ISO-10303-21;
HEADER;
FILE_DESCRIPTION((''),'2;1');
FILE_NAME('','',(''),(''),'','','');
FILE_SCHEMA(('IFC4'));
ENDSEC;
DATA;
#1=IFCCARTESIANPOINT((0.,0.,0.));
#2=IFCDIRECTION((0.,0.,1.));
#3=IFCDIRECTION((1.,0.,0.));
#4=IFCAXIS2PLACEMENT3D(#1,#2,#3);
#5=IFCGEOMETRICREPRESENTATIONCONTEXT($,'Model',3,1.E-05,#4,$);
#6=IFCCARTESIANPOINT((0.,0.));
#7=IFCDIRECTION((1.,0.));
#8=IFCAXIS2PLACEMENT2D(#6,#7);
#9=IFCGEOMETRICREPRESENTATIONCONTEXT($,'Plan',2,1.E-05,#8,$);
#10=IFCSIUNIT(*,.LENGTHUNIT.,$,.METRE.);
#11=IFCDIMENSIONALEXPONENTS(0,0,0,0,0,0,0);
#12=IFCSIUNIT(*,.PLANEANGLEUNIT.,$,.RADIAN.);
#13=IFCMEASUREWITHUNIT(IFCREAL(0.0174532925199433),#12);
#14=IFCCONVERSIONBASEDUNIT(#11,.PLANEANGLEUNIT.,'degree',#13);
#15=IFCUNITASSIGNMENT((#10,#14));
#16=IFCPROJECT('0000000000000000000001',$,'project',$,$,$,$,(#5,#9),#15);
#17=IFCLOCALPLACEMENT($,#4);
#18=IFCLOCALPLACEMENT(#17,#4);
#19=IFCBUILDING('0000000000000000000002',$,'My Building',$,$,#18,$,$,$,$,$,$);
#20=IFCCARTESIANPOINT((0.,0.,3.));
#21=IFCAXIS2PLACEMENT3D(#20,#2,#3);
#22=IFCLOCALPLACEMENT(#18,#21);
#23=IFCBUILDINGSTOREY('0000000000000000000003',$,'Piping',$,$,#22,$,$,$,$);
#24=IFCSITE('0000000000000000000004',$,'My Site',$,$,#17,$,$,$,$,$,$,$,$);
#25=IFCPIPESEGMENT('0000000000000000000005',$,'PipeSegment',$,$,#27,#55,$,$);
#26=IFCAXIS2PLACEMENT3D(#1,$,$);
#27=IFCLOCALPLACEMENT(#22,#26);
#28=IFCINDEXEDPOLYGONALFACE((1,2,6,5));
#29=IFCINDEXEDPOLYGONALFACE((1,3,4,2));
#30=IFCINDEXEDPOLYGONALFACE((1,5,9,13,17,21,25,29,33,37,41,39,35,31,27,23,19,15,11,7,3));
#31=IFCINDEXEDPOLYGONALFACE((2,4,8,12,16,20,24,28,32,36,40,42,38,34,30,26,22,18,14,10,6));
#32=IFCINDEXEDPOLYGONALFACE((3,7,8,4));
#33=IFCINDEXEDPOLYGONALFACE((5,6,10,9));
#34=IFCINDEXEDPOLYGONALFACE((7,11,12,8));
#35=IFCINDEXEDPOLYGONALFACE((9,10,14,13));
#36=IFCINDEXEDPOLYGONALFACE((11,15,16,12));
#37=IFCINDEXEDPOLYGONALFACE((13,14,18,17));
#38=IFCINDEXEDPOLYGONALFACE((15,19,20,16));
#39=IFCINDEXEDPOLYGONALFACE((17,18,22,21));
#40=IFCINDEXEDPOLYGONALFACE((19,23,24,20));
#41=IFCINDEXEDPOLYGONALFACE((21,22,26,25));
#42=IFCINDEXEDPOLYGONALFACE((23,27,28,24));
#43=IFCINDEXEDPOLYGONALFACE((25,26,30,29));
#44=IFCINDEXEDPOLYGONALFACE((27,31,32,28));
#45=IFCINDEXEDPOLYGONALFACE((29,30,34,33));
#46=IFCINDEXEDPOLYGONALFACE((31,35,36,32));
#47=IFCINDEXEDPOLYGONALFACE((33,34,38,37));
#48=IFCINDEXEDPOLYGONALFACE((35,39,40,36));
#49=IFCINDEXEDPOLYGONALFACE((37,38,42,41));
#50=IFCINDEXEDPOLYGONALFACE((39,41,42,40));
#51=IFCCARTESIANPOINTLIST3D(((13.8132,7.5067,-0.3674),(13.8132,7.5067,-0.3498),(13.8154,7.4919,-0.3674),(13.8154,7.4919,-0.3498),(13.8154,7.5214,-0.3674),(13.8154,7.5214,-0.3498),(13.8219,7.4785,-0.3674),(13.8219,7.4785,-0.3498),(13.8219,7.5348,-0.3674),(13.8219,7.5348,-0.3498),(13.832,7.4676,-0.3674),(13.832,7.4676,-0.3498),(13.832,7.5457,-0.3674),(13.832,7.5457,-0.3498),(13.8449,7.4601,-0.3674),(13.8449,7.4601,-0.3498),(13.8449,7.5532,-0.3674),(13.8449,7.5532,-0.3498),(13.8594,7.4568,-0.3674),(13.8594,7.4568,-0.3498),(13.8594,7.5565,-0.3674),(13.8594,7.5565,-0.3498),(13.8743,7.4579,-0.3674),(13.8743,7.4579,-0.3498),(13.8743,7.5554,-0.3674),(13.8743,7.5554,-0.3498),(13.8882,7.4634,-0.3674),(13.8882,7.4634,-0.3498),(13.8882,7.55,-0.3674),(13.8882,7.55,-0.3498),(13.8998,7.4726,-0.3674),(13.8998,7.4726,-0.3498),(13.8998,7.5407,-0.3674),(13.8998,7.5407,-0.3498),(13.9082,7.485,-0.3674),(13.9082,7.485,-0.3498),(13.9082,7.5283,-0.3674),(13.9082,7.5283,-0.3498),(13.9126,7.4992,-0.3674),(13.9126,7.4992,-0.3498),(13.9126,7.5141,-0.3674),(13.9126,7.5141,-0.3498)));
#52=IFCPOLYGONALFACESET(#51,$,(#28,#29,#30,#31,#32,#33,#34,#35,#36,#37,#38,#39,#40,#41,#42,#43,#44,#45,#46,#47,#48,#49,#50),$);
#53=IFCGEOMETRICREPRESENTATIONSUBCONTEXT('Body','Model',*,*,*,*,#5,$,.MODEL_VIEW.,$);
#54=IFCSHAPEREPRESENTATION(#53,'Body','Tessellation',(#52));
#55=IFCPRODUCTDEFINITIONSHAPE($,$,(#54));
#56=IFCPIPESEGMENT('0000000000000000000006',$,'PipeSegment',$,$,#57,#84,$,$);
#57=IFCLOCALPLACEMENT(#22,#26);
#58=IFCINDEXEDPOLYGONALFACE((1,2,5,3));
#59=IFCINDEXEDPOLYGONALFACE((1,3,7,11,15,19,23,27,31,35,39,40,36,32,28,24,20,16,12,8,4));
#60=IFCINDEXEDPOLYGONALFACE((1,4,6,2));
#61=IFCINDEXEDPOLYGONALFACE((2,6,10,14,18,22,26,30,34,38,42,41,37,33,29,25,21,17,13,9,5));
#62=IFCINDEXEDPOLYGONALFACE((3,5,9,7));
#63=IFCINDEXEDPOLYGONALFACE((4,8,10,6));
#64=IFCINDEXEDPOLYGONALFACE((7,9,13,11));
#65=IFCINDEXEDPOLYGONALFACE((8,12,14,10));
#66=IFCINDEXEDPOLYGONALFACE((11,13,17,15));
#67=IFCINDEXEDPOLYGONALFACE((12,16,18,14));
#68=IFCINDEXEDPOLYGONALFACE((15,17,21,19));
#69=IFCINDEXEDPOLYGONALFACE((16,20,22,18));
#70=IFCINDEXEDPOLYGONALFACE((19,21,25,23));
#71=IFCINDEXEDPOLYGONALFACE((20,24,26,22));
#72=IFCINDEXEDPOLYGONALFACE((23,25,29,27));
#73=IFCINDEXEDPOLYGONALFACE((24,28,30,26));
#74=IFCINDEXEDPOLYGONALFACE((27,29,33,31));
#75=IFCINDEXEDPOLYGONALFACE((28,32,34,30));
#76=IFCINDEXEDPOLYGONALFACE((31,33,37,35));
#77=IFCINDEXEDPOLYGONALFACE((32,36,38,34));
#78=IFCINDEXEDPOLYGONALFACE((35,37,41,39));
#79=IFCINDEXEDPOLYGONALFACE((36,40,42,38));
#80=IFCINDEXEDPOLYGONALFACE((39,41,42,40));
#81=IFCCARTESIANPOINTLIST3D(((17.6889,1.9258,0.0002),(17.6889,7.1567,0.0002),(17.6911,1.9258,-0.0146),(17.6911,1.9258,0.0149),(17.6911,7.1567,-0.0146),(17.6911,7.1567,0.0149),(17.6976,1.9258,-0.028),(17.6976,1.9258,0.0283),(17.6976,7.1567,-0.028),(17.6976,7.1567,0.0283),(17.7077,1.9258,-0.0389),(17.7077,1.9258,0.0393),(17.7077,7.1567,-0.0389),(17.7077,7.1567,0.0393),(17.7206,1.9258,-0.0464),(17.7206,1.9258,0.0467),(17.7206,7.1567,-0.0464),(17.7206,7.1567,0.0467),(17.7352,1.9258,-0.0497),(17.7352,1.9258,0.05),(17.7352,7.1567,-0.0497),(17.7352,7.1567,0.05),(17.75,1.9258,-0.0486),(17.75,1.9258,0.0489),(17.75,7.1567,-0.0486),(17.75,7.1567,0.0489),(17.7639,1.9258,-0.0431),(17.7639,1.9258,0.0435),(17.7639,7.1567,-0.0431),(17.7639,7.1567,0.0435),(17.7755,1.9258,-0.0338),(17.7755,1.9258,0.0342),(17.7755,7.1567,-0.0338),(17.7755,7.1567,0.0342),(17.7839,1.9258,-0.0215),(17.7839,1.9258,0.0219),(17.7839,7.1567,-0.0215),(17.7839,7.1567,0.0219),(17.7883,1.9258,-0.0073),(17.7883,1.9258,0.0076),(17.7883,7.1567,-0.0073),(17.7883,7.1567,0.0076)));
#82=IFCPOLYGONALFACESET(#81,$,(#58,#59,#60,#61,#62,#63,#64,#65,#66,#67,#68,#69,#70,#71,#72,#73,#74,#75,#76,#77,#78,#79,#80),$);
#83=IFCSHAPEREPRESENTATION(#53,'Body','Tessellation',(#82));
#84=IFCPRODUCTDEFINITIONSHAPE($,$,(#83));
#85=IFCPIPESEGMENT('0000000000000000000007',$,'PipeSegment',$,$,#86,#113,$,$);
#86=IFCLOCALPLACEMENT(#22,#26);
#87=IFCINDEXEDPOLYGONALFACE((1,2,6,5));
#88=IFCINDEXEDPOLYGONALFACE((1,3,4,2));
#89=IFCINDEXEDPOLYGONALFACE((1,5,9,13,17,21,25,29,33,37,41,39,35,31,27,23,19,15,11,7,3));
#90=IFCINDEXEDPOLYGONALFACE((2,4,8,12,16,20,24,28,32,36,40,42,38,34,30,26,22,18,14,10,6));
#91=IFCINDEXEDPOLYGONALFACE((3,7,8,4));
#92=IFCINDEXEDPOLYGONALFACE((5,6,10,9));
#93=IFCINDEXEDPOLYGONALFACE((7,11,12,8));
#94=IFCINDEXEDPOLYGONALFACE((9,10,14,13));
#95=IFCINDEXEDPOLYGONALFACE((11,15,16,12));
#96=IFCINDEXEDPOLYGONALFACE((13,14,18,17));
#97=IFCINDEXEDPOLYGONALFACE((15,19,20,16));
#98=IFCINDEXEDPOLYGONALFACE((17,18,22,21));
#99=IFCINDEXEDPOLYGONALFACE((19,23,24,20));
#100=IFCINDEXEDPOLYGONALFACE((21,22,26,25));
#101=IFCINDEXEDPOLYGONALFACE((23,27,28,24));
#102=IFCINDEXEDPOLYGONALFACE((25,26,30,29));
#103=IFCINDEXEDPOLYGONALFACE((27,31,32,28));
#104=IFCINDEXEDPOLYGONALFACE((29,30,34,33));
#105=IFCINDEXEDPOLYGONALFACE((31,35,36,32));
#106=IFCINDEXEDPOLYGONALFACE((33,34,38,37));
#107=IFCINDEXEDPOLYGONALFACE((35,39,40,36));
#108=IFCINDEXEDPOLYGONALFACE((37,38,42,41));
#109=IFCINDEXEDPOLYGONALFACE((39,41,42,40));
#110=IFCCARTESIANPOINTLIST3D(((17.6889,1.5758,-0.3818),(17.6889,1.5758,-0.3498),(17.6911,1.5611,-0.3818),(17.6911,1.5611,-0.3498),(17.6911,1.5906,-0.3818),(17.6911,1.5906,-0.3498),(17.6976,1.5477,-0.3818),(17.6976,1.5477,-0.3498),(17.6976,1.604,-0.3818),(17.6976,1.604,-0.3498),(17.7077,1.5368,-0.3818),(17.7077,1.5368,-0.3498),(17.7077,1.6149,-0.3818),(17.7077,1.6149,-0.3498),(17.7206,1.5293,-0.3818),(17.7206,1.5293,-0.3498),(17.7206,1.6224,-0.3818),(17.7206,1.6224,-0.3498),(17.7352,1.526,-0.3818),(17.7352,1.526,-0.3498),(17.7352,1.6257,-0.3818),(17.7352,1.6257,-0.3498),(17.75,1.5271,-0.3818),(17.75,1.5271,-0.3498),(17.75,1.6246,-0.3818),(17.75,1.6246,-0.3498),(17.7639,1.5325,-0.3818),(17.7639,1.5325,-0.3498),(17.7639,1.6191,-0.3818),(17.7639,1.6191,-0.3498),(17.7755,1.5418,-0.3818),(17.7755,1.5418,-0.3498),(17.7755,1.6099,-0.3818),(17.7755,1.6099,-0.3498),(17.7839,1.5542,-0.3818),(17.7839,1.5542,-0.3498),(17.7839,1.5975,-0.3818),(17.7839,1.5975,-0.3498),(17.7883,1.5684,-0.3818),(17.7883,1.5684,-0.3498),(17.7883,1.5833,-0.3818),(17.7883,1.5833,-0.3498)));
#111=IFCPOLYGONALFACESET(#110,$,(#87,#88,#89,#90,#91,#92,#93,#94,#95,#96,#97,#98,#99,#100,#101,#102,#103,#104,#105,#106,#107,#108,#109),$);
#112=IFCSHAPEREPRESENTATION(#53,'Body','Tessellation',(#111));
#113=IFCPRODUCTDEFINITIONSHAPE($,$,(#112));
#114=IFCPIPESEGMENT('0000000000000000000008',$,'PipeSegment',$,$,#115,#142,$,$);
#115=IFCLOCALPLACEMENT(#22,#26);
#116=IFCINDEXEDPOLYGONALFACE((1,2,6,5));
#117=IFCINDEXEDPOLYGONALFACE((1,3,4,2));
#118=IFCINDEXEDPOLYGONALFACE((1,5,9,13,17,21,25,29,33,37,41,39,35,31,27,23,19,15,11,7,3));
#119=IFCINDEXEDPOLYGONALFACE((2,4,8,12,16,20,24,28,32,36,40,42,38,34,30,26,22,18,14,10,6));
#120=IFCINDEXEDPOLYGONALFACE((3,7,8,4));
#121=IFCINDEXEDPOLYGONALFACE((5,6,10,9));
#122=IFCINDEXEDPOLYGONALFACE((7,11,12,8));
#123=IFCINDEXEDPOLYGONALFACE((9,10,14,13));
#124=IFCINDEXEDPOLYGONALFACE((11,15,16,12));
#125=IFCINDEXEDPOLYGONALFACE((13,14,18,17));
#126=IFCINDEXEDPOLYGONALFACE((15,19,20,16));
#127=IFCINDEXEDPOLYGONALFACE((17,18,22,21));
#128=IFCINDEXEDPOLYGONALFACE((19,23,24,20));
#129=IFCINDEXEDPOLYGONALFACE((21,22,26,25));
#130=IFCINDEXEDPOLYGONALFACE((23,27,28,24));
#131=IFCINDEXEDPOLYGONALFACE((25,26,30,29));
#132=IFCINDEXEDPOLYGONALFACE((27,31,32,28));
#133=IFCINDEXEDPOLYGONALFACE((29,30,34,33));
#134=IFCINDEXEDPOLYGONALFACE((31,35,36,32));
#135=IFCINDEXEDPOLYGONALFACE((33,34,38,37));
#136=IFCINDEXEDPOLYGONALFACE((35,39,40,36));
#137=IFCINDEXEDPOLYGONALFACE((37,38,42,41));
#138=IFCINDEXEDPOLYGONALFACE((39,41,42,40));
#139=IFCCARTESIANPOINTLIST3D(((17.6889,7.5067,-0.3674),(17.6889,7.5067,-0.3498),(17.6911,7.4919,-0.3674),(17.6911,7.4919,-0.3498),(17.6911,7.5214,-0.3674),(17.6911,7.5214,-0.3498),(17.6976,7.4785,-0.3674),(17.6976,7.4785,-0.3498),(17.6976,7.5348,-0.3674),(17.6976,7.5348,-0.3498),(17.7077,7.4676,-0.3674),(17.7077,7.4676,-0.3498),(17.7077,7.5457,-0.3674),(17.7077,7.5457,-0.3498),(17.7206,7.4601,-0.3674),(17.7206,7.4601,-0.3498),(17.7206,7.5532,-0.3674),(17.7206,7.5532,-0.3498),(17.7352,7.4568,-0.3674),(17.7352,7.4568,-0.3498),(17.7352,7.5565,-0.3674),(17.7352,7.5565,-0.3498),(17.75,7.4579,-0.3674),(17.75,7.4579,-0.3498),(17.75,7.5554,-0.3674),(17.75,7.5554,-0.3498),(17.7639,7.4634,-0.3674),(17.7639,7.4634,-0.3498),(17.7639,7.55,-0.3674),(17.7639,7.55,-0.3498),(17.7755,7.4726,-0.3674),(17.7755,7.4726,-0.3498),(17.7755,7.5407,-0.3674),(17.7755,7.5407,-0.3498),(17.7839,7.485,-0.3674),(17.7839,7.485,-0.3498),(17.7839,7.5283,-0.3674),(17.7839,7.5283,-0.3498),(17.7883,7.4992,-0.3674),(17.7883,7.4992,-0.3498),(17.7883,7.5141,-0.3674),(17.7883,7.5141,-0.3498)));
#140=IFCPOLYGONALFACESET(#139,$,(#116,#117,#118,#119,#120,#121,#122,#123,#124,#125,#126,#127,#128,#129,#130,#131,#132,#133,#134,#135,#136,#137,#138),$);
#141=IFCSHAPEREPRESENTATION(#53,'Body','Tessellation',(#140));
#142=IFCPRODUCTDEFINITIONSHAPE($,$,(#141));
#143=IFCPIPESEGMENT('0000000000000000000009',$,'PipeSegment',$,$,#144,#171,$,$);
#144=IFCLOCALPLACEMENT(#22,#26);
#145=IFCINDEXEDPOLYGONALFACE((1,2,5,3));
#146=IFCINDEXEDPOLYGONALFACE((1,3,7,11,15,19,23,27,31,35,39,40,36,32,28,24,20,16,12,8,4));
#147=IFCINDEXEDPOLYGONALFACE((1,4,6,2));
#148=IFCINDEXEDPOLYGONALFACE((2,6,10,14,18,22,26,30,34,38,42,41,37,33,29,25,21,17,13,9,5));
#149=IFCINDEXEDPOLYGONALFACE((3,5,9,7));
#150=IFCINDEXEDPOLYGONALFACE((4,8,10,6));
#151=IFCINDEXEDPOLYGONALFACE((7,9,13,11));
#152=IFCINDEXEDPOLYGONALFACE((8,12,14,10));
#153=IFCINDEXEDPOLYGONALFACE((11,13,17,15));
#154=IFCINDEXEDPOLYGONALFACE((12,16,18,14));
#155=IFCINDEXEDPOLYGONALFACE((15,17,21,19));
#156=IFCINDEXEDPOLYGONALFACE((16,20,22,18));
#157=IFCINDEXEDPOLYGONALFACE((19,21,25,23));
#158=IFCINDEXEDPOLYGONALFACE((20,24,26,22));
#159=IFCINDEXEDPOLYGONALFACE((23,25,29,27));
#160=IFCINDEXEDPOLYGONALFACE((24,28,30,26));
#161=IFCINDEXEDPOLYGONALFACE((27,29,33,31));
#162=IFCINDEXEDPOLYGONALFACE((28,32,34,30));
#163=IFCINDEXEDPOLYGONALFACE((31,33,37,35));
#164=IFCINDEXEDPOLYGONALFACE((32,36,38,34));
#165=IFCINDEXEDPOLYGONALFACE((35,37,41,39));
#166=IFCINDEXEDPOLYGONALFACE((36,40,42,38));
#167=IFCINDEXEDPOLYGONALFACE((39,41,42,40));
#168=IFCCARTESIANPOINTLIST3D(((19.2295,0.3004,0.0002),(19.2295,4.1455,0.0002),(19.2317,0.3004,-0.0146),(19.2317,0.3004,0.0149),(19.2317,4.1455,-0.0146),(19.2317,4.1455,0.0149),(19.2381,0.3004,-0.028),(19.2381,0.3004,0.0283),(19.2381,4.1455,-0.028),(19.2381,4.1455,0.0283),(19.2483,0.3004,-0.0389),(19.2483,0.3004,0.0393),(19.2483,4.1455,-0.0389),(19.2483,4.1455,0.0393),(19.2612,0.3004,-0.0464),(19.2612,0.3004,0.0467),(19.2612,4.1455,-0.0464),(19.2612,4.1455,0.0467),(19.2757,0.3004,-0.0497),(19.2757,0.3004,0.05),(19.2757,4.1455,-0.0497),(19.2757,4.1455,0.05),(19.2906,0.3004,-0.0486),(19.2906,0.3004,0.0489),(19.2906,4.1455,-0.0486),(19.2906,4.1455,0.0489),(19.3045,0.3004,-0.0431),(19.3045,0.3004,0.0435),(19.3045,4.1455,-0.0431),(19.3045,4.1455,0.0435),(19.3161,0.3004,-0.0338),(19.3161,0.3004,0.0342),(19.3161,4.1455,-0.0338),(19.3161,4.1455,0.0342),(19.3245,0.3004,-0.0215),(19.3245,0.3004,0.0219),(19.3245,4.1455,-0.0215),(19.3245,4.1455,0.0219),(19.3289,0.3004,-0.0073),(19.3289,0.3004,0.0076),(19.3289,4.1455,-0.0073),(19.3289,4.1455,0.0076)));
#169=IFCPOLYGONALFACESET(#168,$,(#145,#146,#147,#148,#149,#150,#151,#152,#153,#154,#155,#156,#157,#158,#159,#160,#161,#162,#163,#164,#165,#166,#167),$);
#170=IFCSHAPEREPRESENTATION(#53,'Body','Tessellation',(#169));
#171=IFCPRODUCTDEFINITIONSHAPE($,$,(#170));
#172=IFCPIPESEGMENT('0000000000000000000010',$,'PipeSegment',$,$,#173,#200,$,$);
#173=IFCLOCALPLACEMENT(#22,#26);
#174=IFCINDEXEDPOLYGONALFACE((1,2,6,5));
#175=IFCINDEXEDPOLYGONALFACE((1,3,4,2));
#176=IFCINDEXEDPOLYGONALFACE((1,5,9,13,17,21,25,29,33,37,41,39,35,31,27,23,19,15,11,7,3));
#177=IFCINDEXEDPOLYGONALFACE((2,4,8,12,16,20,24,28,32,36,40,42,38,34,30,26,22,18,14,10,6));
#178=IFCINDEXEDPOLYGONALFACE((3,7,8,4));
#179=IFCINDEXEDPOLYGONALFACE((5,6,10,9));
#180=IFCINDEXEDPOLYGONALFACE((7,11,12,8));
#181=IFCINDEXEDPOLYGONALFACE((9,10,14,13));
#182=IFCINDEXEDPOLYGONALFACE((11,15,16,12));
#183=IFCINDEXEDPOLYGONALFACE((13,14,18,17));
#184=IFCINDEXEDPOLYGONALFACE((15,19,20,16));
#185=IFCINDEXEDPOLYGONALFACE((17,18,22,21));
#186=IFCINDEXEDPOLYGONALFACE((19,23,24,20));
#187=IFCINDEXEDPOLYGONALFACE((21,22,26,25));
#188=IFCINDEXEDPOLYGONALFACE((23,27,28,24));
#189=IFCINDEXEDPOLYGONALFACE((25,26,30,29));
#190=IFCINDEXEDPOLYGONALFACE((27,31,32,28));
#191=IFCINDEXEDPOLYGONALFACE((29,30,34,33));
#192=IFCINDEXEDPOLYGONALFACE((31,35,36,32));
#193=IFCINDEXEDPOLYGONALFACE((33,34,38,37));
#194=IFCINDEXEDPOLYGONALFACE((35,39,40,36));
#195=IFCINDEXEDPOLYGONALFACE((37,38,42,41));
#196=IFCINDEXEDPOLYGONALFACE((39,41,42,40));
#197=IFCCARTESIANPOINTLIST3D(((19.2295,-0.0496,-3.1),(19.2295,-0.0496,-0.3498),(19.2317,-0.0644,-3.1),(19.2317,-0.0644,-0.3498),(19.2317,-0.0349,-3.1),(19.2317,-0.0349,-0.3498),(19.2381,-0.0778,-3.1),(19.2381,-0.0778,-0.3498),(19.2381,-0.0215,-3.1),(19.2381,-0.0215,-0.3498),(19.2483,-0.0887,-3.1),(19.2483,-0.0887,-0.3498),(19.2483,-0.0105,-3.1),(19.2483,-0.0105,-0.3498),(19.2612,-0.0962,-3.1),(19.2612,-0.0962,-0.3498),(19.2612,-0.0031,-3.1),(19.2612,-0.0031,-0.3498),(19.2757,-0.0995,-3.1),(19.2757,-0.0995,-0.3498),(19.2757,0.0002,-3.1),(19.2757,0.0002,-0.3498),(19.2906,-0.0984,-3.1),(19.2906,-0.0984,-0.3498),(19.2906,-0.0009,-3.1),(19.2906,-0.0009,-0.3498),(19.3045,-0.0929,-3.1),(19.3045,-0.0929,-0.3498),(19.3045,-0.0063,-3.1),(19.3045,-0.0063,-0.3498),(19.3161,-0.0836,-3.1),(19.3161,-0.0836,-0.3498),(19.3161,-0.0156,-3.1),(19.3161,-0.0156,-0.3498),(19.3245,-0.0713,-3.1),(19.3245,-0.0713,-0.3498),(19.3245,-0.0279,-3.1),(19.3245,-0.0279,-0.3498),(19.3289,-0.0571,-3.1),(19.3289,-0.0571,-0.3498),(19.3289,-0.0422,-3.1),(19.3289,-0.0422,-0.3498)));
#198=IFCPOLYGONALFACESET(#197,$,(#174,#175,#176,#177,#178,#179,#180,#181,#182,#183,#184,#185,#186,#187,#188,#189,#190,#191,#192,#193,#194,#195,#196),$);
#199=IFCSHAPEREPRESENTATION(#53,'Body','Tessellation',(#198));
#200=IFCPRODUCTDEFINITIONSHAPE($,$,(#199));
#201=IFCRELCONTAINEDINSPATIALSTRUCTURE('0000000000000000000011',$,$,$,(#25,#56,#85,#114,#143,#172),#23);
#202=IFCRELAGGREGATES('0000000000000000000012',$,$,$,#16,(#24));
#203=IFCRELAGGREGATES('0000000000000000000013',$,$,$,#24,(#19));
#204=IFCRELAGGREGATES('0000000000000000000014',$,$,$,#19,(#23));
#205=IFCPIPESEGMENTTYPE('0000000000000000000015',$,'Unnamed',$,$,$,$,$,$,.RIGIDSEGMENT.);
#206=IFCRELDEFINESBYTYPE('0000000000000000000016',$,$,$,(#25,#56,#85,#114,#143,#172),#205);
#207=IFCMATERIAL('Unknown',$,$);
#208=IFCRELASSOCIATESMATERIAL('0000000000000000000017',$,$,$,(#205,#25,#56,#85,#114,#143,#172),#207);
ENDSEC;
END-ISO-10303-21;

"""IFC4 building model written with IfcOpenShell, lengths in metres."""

from ifc_helpers import new_model, entity, si_unit, converted_unit, frame, origin_with_axes, origin_2d_with_axis, place, context, subcontext, project, spatial, circle, extrude, material, material_profile, profile_set, profile_usage, type_object, element, save


model = new_model("IFC4")

# Units and contexts
model_context = context("Model", 3, precision=1e-05, world=origin_with_axes())
plan_context = context("Plan", 2, precision=1e-05, world=origin_2d_with_axis())
body_context = subcontext(model_context, "Body", "Model", "MODEL_VIEW")
ifc_project = project(units=[si_unit("LENGTHUNIT", "METRE"), converted_unit("PLANEANGLEUNIT", "degree", entity("IfcReal", 0.0174532925199433), si_unit("PLANEANGLEUNIT", "RADIAN"), dimensions=[0, 0, 0, 0, 0, 0, 0])], contexts=[model_context, plan_context])

# Site, building, storey
site_placement = place(None, origin_with_axes())
site = spatial("IfcSite", under=ifc_project, at=site_placement, Name="My Site")
building_placement = place(site_placement, origin_with_axes())
building = spatial("IfcBuilding", under=site, at=building_placement, Name="My Building")
storey_placement = place(building_placement, frame((0.0, 0.0, 3.0), z_axis=(0.0, 0.0, 1.0), x_axis=(1.0, 0.0, 0.0)))
storey = spatial("IfcBuildingStorey", under=building, at=storey_placement, Name="Piping")

# Pipe segments
ifc_material = material(Name="Unknown")
ifc_material_profile = material_profile(ifc_material, circle(Radius=0.05))
ifc_profile_set = profile_set([ifc_material_profile])
pipe_segment_type = type_object("IfcPipeSegmentType", Name="Unnamed", PredefinedType="RIGIDSEGMENT", material=ifc_profile_set)
ifc_profile_usage_1 = profile_usage(ifc_profile_set, cardinal=5)
pipe_segment_1_placement = place(storey_placement, frame((13.8632, 7.5067, -0.3498), z_axis=(0.0, 0.0, -1.0), x_axis=(-1.0, 0.0, 0.0)))
element("IfcPipeSegment", 1, at=pipe_segment_1_placement, inside=storey, type_object=pipe_segment_type, material=ifc_profile_usage_1, Name="PipeSegment", context=body_context, shape_type="SweptSolid", body=[
    extrude(circle(Radius=0.05), origin_with_axes(), (0.0, 0.0, 1.0), 0.0175),
])
ifc_profile_usage_2 = profile_usage(ifc_profile_set, cardinal=5)
pipe_segment_2_placement = place(storey_placement, frame((17.7389, 1.9258, 0.0002), z_axis=(0.0, 1.0, 0.0), x_axis=(-1.0, 0.0, 0.0)))
element("IfcPipeSegment", 2, at=pipe_segment_2_placement, inside=storey, type_object=pipe_segment_type, material=ifc_profile_usage_2, Name="PipeSegment", context=body_context, shape_type="SweptSolid", body=[
    extrude(circle(Radius=0.05), origin_with_axes(), (0.0, 0.0, 1.0), 5.2308),
])
ifc_profile_usage_3 = profile_usage(ifc_profile_set, cardinal=5)
pipe_segment_3_placement = place(storey_placement, frame((17.7389, 1.5758, -0.3498), z_axis=(0.0, 0.0, -1.0), x_axis=(-1.0, 0.0, 0.0)))
element("IfcPipeSegment", 3, at=pipe_segment_3_placement, inside=storey, type_object=pipe_segment_type, material=ifc_profile_usage_3, Name="PipeSegment", context=body_context, shape_type="SweptSolid", body=[
    extrude(circle(Radius=0.05), origin_with_axes(), (0.0, 0.0, 1.0), 0.0319),
])
ifc_profile_usage_4 = profile_usage(ifc_profile_set, cardinal=5)
pipe_segment_4_placement = place(storey_placement, frame((17.7389, 7.5067, -0.3498), z_axis=(0.0, 0.0, -1.0), x_axis=(-1.0, 0.0, 0.0)))
element("IfcPipeSegment", 4, at=pipe_segment_4_placement, inside=storey, type_object=pipe_segment_type, material=ifc_profile_usage_4, Name="PipeSegment", context=body_context, shape_type="SweptSolid", body=[
    extrude(circle(Radius=0.05), origin_with_axes(), (0.0, 0.0, 1.0), 0.0175),
])
ifc_profile_usage_5 = profile_usage(ifc_profile_set, cardinal=5)
pipe_segment_5_placement = place(storey_placement, frame((19.2795, 0.3004, 0.0002), z_axis=(0.0, 1.0, 0.0), x_axis=(-1.0, 0.0, 0.0)))
element("IfcPipeSegment", 5, at=pipe_segment_5_placement, inside=storey, type_object=pipe_segment_type, material=ifc_profile_usage_5, Name="PipeSegment", context=body_context, shape_type="SweptSolid", body=[
    extrude(circle(Radius=0.05), origin_with_axes(), (0.0, 0.0, 1.0), 3.8451),
])
ifc_profile_usage_6 = profile_usage(ifc_profile_set, cardinal=5)
pipe_segment_6_placement = place(storey_placement, frame((19.2795, -0.0496, -0.3498), z_axis=(0.0, 0.0, -1.0), x_axis=(-1.0, 0.0, 0.0)))
element("IfcPipeSegment", 6, at=pipe_segment_6_placement, inside=storey, type_object=pipe_segment_type, material=ifc_profile_usage_6, Name="PipeSegment", context=body_context, shape_type="SweptSolid", body=[
    extrude(circle(Radius=0.05), origin_with_axes(), (0.0, 0.0, 1.0), 2.7501),
])

save(model, "model.ifc")
